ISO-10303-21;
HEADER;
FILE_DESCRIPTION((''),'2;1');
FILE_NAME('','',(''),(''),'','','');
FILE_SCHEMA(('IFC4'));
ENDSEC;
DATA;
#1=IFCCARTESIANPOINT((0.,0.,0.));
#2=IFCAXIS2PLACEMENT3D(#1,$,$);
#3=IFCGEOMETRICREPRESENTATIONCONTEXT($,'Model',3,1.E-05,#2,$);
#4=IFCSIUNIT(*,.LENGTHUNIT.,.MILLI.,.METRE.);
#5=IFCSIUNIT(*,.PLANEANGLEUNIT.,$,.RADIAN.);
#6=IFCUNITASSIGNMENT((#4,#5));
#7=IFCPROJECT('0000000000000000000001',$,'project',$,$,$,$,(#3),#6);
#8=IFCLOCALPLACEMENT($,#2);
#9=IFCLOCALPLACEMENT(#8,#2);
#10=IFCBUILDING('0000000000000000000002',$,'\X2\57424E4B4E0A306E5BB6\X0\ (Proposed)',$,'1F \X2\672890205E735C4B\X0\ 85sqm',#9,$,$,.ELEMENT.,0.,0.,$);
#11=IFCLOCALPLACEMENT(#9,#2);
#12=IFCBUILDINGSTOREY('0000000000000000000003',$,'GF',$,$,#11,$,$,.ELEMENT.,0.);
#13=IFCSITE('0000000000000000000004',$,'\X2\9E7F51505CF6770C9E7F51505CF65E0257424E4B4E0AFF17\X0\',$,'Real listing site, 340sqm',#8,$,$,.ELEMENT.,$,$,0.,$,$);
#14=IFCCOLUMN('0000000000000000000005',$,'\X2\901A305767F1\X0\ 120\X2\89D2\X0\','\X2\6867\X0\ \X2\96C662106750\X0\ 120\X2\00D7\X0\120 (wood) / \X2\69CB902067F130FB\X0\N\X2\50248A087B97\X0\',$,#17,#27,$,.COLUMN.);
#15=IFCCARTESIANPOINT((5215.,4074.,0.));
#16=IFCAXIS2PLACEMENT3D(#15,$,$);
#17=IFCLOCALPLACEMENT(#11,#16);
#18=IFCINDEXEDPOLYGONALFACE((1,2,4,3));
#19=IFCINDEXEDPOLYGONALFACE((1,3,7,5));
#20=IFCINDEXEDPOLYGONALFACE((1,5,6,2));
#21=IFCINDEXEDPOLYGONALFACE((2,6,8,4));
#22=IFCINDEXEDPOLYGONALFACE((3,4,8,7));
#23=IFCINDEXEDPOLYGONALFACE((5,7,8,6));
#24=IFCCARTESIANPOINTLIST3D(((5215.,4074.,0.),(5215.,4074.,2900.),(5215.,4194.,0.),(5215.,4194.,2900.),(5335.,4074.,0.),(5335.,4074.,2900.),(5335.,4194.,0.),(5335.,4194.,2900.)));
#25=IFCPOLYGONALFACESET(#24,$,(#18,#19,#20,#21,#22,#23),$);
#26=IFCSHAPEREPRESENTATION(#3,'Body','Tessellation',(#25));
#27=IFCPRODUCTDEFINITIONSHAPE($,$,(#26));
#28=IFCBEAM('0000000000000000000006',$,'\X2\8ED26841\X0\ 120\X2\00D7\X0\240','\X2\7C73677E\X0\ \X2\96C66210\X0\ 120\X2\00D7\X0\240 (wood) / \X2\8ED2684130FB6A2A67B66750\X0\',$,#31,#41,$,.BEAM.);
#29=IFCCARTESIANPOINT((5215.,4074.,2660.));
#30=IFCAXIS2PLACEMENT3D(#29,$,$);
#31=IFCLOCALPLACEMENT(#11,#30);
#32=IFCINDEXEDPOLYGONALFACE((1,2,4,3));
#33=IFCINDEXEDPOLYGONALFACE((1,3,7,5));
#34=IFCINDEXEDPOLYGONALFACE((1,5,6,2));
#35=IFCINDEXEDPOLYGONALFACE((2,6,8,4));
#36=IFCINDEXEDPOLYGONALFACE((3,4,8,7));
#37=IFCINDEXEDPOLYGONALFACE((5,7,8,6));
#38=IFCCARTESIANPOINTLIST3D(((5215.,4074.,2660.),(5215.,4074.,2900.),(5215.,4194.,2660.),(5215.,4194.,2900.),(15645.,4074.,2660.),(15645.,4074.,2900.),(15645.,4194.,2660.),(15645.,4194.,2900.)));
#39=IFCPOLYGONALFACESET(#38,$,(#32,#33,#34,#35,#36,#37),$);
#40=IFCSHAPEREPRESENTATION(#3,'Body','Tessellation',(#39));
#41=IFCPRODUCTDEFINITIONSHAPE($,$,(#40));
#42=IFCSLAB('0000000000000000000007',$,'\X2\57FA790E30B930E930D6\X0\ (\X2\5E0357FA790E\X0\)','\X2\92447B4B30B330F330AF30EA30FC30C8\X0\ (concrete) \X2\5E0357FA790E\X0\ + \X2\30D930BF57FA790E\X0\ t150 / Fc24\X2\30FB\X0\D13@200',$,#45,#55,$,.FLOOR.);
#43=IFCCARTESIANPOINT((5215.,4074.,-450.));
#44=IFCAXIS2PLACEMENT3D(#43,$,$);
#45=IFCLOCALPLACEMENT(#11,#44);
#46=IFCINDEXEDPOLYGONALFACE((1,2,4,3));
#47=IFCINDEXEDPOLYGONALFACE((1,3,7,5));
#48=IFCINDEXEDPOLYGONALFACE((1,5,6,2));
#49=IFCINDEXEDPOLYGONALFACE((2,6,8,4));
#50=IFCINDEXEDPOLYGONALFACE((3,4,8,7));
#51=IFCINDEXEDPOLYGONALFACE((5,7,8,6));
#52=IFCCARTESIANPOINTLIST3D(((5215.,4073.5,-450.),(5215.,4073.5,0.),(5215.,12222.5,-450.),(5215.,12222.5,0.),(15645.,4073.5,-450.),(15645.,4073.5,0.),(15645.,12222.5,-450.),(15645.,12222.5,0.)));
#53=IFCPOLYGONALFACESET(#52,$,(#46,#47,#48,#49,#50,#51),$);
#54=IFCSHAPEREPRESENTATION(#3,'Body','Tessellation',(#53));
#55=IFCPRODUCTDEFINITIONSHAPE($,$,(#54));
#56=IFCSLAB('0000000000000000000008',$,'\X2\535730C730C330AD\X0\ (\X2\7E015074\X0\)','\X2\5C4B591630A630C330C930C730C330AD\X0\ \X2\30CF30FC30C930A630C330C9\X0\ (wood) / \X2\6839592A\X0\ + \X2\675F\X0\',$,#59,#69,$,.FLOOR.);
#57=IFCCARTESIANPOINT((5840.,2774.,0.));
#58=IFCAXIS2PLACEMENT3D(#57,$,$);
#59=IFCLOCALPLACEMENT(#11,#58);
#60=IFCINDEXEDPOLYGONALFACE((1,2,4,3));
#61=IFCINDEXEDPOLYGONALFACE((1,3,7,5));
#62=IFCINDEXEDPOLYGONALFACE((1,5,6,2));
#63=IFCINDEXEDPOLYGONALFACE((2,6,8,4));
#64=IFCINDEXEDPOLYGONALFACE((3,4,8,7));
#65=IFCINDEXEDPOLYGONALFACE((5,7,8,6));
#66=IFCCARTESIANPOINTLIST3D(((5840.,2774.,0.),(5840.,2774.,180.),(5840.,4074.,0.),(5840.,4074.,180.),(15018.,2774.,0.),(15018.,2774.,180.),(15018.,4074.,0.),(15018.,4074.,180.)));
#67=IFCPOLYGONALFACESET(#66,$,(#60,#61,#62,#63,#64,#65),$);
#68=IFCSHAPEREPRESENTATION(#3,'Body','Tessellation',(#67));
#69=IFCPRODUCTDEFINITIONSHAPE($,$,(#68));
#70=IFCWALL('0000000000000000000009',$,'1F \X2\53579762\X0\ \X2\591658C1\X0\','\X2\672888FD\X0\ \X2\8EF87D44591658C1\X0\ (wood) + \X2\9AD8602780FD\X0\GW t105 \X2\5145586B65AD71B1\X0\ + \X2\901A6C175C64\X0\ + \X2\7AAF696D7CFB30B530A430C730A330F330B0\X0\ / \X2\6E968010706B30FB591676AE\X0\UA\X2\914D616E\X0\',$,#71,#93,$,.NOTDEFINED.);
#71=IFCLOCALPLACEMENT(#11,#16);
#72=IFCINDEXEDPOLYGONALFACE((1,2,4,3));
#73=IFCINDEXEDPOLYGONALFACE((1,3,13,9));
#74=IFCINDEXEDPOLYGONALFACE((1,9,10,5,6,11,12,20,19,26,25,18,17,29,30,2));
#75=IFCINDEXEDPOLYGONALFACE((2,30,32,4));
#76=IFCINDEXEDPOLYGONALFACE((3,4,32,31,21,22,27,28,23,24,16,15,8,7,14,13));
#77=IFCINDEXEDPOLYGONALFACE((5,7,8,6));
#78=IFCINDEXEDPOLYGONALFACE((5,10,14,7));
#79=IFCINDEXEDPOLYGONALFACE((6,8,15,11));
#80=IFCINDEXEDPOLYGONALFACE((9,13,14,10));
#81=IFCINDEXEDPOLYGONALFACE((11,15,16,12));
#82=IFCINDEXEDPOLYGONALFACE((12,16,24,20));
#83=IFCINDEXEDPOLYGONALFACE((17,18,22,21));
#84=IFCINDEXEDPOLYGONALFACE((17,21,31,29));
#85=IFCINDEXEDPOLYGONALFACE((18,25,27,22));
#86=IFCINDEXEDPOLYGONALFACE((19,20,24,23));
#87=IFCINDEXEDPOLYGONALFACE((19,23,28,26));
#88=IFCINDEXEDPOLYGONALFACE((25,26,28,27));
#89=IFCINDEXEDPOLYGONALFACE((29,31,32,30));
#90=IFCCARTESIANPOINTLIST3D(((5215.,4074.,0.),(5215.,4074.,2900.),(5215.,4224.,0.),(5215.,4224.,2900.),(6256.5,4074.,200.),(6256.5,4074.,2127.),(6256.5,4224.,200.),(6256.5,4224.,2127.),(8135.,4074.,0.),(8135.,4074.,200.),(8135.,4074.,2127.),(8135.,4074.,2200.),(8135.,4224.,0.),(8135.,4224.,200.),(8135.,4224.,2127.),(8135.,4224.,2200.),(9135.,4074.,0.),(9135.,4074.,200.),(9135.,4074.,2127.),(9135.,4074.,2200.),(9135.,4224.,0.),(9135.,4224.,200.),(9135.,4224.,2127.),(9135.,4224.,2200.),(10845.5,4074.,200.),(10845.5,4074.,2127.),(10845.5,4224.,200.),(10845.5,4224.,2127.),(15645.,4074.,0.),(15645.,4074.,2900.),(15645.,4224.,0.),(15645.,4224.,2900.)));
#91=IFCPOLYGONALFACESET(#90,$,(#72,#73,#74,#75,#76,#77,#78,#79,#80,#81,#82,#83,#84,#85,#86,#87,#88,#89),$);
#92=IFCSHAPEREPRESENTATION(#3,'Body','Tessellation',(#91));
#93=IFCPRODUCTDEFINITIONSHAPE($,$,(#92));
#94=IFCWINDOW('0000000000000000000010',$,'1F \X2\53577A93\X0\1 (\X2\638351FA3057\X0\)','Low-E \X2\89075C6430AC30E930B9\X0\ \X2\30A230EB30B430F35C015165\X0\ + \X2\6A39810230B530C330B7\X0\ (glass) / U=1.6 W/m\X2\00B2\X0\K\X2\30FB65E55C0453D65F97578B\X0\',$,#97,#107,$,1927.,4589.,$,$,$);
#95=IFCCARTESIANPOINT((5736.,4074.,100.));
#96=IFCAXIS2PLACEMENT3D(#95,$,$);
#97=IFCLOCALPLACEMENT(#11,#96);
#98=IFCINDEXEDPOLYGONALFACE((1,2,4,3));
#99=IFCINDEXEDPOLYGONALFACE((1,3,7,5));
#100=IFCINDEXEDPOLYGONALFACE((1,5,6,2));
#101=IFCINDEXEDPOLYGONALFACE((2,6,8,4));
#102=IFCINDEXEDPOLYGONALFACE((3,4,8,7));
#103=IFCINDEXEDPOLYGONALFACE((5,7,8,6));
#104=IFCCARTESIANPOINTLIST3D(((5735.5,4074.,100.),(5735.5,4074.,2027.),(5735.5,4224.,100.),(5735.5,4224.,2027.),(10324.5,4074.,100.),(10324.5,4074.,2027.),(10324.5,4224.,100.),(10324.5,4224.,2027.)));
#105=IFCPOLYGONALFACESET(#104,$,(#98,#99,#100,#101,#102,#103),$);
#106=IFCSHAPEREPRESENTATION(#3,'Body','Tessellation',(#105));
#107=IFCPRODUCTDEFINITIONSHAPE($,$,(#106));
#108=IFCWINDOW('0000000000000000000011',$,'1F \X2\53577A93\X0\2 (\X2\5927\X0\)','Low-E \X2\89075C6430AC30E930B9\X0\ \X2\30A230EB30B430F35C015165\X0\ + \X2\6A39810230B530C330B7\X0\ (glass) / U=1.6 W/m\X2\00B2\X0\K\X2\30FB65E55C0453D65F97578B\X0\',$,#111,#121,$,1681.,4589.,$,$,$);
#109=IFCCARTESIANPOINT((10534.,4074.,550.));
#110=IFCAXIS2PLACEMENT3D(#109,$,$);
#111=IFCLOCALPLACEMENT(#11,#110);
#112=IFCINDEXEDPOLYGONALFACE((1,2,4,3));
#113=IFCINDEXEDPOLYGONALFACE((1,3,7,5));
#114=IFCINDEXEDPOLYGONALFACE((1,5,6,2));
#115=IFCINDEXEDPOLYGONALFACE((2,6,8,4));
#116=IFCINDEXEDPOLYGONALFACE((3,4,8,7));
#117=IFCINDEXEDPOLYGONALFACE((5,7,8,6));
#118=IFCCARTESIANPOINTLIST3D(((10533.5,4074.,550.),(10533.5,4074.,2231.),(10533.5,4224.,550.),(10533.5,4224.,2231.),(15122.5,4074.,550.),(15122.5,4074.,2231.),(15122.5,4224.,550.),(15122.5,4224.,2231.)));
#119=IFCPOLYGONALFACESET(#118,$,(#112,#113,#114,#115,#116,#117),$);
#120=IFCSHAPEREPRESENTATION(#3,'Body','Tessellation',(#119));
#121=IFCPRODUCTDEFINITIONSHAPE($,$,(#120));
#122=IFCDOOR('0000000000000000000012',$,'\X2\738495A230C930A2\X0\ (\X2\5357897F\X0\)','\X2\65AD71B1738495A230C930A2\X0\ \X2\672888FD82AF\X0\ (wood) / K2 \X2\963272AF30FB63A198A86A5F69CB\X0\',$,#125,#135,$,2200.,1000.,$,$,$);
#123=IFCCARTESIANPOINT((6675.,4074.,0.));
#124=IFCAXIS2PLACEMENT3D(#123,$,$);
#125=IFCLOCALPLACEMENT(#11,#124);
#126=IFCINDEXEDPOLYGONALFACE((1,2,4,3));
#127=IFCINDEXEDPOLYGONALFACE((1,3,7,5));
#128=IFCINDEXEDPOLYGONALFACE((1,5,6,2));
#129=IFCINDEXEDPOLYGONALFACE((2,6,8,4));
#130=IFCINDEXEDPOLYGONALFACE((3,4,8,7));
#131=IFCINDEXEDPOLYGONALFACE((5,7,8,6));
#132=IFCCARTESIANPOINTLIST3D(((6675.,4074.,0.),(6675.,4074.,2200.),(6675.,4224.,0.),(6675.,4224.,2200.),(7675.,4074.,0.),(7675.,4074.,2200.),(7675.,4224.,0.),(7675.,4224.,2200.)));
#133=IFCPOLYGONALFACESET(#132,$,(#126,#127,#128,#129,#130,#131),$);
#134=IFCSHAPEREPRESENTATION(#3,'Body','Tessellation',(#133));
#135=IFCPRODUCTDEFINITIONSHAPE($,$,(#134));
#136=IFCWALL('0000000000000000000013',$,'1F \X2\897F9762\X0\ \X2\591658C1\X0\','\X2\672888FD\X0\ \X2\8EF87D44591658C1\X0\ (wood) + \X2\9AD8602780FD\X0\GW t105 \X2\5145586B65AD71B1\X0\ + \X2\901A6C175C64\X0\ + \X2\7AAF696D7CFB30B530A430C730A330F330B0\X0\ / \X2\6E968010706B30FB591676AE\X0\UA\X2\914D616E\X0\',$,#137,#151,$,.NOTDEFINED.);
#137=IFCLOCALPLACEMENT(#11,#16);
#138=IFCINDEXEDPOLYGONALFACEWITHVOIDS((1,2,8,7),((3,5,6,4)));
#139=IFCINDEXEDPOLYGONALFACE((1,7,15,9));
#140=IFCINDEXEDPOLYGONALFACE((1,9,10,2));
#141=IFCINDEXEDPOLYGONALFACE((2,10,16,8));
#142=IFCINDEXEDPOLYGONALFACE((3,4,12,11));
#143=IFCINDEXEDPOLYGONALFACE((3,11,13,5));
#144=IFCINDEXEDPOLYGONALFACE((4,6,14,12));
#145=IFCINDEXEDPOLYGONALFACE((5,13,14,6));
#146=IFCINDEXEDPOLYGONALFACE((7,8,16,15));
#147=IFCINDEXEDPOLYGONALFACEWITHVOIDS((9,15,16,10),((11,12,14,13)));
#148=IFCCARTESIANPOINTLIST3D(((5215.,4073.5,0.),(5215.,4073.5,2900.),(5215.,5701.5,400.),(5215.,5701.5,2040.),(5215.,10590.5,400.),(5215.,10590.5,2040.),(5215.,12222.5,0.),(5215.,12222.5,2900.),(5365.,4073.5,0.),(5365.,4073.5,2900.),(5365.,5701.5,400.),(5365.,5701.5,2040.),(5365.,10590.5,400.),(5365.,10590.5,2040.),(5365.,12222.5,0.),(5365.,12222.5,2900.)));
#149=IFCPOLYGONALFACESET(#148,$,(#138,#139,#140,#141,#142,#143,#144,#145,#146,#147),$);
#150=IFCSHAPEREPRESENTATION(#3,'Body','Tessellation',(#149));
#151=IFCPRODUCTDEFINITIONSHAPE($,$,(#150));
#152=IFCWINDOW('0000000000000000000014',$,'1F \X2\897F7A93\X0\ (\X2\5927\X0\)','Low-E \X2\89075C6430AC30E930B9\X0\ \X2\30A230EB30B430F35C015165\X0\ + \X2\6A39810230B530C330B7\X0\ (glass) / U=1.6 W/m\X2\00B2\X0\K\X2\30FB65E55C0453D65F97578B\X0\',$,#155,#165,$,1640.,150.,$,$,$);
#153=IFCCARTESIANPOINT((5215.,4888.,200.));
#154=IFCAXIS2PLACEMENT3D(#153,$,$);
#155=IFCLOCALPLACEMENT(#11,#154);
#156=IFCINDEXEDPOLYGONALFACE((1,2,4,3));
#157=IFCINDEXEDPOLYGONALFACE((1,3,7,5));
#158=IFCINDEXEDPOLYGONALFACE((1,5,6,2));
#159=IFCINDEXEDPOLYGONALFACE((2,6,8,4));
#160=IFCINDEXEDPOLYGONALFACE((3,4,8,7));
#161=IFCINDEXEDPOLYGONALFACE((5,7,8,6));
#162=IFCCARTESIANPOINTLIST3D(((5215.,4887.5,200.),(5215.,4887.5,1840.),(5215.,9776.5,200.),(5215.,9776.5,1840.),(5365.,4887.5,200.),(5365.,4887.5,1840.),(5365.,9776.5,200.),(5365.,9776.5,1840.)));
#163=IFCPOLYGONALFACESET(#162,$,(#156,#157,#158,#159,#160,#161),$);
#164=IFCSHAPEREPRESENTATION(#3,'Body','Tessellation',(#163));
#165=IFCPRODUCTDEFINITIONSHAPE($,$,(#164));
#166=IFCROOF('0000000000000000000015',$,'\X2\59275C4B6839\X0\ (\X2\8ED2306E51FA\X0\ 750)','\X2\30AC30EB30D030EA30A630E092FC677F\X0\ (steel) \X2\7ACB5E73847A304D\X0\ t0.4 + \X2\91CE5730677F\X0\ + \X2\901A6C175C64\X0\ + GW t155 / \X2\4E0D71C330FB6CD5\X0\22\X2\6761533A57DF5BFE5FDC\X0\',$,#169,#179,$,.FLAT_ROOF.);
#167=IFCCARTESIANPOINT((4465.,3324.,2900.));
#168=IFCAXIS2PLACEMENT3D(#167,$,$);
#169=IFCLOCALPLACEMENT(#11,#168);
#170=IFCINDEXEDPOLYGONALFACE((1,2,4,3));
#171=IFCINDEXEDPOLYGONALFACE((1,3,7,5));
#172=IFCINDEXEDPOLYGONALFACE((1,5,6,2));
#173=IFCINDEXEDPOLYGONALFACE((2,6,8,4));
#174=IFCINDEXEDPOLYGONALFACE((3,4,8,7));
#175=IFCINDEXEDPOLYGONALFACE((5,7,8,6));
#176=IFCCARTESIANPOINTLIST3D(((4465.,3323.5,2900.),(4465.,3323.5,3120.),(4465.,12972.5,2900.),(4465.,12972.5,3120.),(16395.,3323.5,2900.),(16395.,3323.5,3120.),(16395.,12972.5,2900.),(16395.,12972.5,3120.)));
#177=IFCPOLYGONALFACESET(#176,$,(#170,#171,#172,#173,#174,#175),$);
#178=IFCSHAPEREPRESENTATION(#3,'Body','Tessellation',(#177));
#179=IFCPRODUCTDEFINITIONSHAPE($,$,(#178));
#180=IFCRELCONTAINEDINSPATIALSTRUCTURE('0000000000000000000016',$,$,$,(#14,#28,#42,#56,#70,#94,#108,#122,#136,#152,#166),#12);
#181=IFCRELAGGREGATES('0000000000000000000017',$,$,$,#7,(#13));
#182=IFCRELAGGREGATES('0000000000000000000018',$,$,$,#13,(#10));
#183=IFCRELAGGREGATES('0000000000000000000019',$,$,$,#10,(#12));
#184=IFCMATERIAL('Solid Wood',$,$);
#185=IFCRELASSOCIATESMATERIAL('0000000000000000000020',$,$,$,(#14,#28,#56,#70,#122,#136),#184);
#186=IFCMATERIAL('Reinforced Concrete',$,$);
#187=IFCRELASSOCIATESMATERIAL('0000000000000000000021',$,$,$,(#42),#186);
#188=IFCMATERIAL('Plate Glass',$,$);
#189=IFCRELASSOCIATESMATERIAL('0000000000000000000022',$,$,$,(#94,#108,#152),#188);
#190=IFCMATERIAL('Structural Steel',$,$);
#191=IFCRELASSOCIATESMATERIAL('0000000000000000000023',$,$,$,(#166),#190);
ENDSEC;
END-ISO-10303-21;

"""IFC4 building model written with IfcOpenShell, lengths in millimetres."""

from ifc_helpers import new_model, si_unit, frame, frame_2d, origin, place, context, project, spatial, rectangle, extrude, material, element, fill, save


model = new_model("IFC4")

# Units and contexts
model_context = context("Model", 3, precision=1e-05, world=origin())
ifc_project = project(units=[si_unit("LENGTHUNIT", "METRE", prefix="MILLI"), si_unit("PLANEANGLEUNIT", "RADIAN")], contexts=[model_context])

# Site, building, storey
site_placement = place(None, origin())
site = spatial("IfcSite", under=ifc_project, at=site_placement, Name="鹿児島県鹿児島市坂之上７", ObjectType="Real listing site, 340sqm", CompositionType="ELEMENT", RefElevation=0.0)
building_placement = place(site_placement, origin())
building = spatial("IfcBuilding", under=site, at=building_placement, Name="坂之上の家 (Proposed)", ObjectType="1F 木造平屋 85sqm", CompositionType="ELEMENT", ElevationOfRefHeight=0.0, ElevationOfTerrain=0.0)
storey_placement = place(building_placement, origin())
storey = spatial("IfcBuildingStorey", under=building, at=storey_placement, Name="GF", CompositionType="ELEMENT", Elevation=0.0)

# Column
ifc_material_1 = material(Name="Solid Wood")
column_1_placement = place(storey_placement, frame((5215.0, 4074.0, 0.0)))
element("IfcColumn", 1, at=column_1_placement, inside=storey, material=ifc_material_1, Name="通し柱 120角", Description="桧 集成材 120×120 (wood) / 構造柱・N値計算", PredefinedType="COLUMN", context=model_context, shape_type="SweptSolid", body=[
    extrude(rectangle(XDim=120.0, YDim=120.0, at=frame_2d((60.0, 60.0))), frame((5215.0, 4074.0, 0.0)), (0.0, 0.0, 1.0), 2900.0),
])

# Beam
beam_1_placement = place(storey_placement, frame((5215.0, 4074.0, 2660.0)))
element("IfcBeam", 2, at=beam_1_placement, inside=storey, material=ifc_material_1, Name="軒桁 120×240", Description="米松 集成 120×240 (wood) / 軒桁・横架材", PredefinedType="BEAM", context=model_context, shape_type="SweptSolid", body=[
    extrude(rectangle(XDim=10430.0, YDim=120.0, at=frame_2d((5215.0, 60.0))), frame((5215.0, 4074.0, 2660.0)), (0.0, 0.0, 1.0), 240.0),
])

# Slabs
ifc_material_2 = material(Name="Reinforced Concrete")
slab_1_placement = place(storey_placement, frame((5215.0, 4074.0, -450.0)))
element("IfcSlab", 3, at=slab_1_placement, inside=storey, material=ifc_material_2, Name="基礎スラブ (布基礎)", Description="鉄筋コンクリート (concrete) 布基礎 + ベタ基礎 t150 / Fc24・D13@200", PredefinedType="FLOOR", context=model_context, shape_type="SweptSolid", body=[
    extrude(rectangle(XDim=10430.0, YDim=8149.0, at=frame_2d((5215.0, 4074.0))), frame((5215.0, 4074.0, -450.0)), (0.0, 0.0, 1.0), 450.0),
])
slab_2_placement = place(storey_placement, frame((5840.0, 2774.0, 0.0)))
element("IfcSlab", 4, at=slab_2_placement, inside=storey, material=ifc_material_1, Name="南デッキ (縁側)", Description="屋外ウッドデッキ ハードウッド (wood) / 根太 + 束", PredefinedType="FLOOR", context=model_context, shape_type="SweptSolid", body=[
    extrude(rectangle(XDim=9178.0, YDim=1300.0, at=frame_2d((4589.0, 650.0))), frame((5840.0, 2774.0, 0.0)), (0.0, 0.0, 1.0), 180.0),
])

# Wall, openings, windows, door
wall_1_placement = place(storey_placement, frame((5215.0, 4074.0, 0.0)))
wall_1 = element("IfcWall", 5, at=wall_1_placement, inside=storey, material=ifc_material_1, Name="1F 南面 外壁", Description="木製 軸組外壁 (wood) + 高性能GW t105 充填断熱 + 通気層 + 窯業系サイディング / 準耐火・外皮UA配慮", PredefinedType="NOTDEFINED", context=model_context, shape_type="SweptSolid", body=[
    extrude(rectangle(XDim=10430.0, YDim=150.0, at=frame_2d((5215.0, 75.0))), frame((5215.0, 4074.0, 0.0)), (0.0, 0.0, 1.0), 2900.0),
])
opening_1_placement = place(storey_placement, frame((5736.0, 4074.0, 100.0)))
opening_1 = element("IfcOpeningElement", 6, at=opening_1_placement, cuts=wall_1, PredefinedType="NOTDEFINED", context=model_context, shape_type="SweptSolid", body=[
    extrude(rectangle(XDim=4589.0, YDim=150.0, at=frame_2d((2294.0, 75.0))), frame((5736.0, 4074.0, 100.0)), (0.0, 0.0, 1.0), 1927.0),
])
opening_2_placement = place(storey_placement, frame((10534.0, 4074.0, 550.0)))
opening_2 = element("IfcOpeningElement", 7, at=opening_2_placement, cuts=wall_1, PredefinedType="NOTDEFINED", context=model_context, shape_type="SweptSolid", body=[
    extrude(rectangle(XDim=4589.0, YDim=150.0, at=frame_2d((2294.0, 75.0))), frame((10534.0, 4074.0, 550.0)), (0.0, 0.0, 1.0), 1681.0),
])
opening_3_placement = place(storey_placement, frame((6675.0, 4074.0, 0.0)))
opening_3 = element("IfcOpeningElement", 8, at=opening_3_placement, cuts=wall_1, PredefinedType="NOTDEFINED", context=model_context, shape_type="SweptSolid", body=[
    extrude(rectangle(XDim=1000.0, YDim=150.0, at=frame_2d((500.0, 75.0))), frame((6675.0, 4074.0, 0.0)), (0.0, 0.0, 1.0), 2200.0),
])
ifc_material_3 = material(Name="Plate Glass")
window_1_placement = place(storey_placement, frame((5736.0, 4074.0, 100.0)))
window_1 = element("IfcWindow", 9, at=window_1_placement, inside=storey, material=ifc_material_3, Name="1F 南窓1 (掃出し)", Description="Low-E 複層ガラス アルゴン封入 + 樹脂サッシ (glass) / U=1.6 W/m²K・日射取得型", OverallHeight=1927.0, OverallWidth=4589.0, context=model_context, shape_type="SweptSolid", body=[
    extrude(rectangle(XDim=4589.0, YDim=150.0, at=frame_2d((2294.0, 75.0))), frame((5736.0, 4074.0, 100.0)), (0.0, 0.0, 1.0), 1927.0),
])
fill(opening_1, window_1)
window_2_placement = place(storey_placement, frame((10534.0, 4074.0, 550.0)))
window_2 = element("IfcWindow", 10, at=window_2_placement, inside=storey, material=ifc_material_3, Name="1F 南窓2 (大)", Description="Low-E 複層ガラス アルゴン封入 + 樹脂サッシ (glass) / U=1.6 W/m²K・日射取得型", OverallHeight=1681.0, OverallWidth=4589.0, context=model_context, shape_type="SweptSolid", body=[
    extrude(rectangle(XDim=4589.0, YDim=150.0, at=frame_2d((2294.0, 75.0))), frame((10534.0, 4074.0, 550.0)), (0.0, 0.0, 1.0), 1681.0),
])
fill(opening_2, window_2)
door_placement = place(storey_placement, frame((6675.0, 4074.0, 0.0)))
door = element("IfcDoor", 11, at=door_placement, inside=storey, material=ifc_material_1, Name="玄関ドア (南西)", Description="断熱玄関ドア 木製芯 (wood) / K2 防犯・採風機構", OverallHeight=2200.0, OverallWidth=1000.0, context=model_context, shape_type="SweptSolid", body=[
    extrude(rectangle(XDim=1000.0, YDim=150.0, at=frame_2d((500.0, 75.0))), frame((6675.0, 4074.0, 0.0)), (0.0, 0.0, 1.0), 2200.0),
])
fill(opening_3, door)

# Wall, opening, window
wall_2_placement = place(storey_placement, frame((5215.0, 4074.0, 0.0)))
wall_2 = element("IfcWall", 12, at=wall_2_placement, inside=storey, material=ifc_material_1, Name="1F 西面 外壁", Description="木製 軸組外壁 (wood) + 高性能GW t105 充填断熱 + 通気層 + 窯業系サイディング / 準耐火・外皮UA配慮", PredefinedType="NOTDEFINED", context=model_context, shape_type="SweptSolid", body=[
    extrude(rectangle(XDim=150.0, YDim=8149.0, at=frame_2d((75.0, 4074.0))), frame((5215.0, 4074.0, 0.0)), (0.0, 0.0, 1.0), 2900.0),
])
opening_4_placement = place(storey_placement, frame((5215.0, 4888.0, 200.0)))
opening_4 = element("IfcOpeningElement", 13, at=opening_4_placement, cuts=wall_2, PredefinedType="NOTDEFINED", context=model_context, shape_type="SweptSolid", body=[
    extrude(rectangle(XDim=150.0, YDim=4889.0, at=frame_2d((75.0, 2444.0))), frame((5215.0, 4888.0, 200.0)), (0.0, 0.0, 1.0), 1640.0),
])
window_3_placement = place(storey_placement, frame((5215.0, 4888.0, 200.0)))
window_3 = element("IfcWindow", 14, at=window_3_placement, inside=storey, material=ifc_material_3, Name="1F 西窓 (大)", Description="Low-E 複層ガラス アルゴン封入 + 樹脂サッシ (glass) / U=1.6 W/m²K・日射取得型", OverallHeight=1640.0, OverallWidth=150.0, context=model_context, shape_type="SweptSolid", body=[
    extrude(rectangle(XDim=150.0, YDim=4889.0, at=frame_2d((75.0, 2444.0))), frame((5215.0, 4888.0, 200.0)), (0.0, 0.0, 1.0), 1640.0),
])
fill(opening_4, window_3)

# Roof
ifc_material_4 = material(Name="Structural Steel")
roof_placement = place(storey_placement, frame((4465.0, 3324.0, 2900.0)))
element("IfcRoof", 15, at=roof_placement, inside=storey, material=ifc_material_4, Name="大屋根 (軒の出 750)", Description="ガルバリウム鋼板 (steel) 立平葺き t0.4 + 野地板 + 通気層 + GW t155 / 不燃・法22条区域対応", PredefinedType="FLAT_ROOF", context=model_context, shape_type="SweptSolid", body=[
    extrude(rectangle(XDim=11930.0, YDim=9649.0, at=frame_2d((5965.0, 4824.0))), frame((4465.0, 3324.0, 2900.0)), (0.0, 0.0, 1.0), 220.0),
])

save(model, "model.ifc")
